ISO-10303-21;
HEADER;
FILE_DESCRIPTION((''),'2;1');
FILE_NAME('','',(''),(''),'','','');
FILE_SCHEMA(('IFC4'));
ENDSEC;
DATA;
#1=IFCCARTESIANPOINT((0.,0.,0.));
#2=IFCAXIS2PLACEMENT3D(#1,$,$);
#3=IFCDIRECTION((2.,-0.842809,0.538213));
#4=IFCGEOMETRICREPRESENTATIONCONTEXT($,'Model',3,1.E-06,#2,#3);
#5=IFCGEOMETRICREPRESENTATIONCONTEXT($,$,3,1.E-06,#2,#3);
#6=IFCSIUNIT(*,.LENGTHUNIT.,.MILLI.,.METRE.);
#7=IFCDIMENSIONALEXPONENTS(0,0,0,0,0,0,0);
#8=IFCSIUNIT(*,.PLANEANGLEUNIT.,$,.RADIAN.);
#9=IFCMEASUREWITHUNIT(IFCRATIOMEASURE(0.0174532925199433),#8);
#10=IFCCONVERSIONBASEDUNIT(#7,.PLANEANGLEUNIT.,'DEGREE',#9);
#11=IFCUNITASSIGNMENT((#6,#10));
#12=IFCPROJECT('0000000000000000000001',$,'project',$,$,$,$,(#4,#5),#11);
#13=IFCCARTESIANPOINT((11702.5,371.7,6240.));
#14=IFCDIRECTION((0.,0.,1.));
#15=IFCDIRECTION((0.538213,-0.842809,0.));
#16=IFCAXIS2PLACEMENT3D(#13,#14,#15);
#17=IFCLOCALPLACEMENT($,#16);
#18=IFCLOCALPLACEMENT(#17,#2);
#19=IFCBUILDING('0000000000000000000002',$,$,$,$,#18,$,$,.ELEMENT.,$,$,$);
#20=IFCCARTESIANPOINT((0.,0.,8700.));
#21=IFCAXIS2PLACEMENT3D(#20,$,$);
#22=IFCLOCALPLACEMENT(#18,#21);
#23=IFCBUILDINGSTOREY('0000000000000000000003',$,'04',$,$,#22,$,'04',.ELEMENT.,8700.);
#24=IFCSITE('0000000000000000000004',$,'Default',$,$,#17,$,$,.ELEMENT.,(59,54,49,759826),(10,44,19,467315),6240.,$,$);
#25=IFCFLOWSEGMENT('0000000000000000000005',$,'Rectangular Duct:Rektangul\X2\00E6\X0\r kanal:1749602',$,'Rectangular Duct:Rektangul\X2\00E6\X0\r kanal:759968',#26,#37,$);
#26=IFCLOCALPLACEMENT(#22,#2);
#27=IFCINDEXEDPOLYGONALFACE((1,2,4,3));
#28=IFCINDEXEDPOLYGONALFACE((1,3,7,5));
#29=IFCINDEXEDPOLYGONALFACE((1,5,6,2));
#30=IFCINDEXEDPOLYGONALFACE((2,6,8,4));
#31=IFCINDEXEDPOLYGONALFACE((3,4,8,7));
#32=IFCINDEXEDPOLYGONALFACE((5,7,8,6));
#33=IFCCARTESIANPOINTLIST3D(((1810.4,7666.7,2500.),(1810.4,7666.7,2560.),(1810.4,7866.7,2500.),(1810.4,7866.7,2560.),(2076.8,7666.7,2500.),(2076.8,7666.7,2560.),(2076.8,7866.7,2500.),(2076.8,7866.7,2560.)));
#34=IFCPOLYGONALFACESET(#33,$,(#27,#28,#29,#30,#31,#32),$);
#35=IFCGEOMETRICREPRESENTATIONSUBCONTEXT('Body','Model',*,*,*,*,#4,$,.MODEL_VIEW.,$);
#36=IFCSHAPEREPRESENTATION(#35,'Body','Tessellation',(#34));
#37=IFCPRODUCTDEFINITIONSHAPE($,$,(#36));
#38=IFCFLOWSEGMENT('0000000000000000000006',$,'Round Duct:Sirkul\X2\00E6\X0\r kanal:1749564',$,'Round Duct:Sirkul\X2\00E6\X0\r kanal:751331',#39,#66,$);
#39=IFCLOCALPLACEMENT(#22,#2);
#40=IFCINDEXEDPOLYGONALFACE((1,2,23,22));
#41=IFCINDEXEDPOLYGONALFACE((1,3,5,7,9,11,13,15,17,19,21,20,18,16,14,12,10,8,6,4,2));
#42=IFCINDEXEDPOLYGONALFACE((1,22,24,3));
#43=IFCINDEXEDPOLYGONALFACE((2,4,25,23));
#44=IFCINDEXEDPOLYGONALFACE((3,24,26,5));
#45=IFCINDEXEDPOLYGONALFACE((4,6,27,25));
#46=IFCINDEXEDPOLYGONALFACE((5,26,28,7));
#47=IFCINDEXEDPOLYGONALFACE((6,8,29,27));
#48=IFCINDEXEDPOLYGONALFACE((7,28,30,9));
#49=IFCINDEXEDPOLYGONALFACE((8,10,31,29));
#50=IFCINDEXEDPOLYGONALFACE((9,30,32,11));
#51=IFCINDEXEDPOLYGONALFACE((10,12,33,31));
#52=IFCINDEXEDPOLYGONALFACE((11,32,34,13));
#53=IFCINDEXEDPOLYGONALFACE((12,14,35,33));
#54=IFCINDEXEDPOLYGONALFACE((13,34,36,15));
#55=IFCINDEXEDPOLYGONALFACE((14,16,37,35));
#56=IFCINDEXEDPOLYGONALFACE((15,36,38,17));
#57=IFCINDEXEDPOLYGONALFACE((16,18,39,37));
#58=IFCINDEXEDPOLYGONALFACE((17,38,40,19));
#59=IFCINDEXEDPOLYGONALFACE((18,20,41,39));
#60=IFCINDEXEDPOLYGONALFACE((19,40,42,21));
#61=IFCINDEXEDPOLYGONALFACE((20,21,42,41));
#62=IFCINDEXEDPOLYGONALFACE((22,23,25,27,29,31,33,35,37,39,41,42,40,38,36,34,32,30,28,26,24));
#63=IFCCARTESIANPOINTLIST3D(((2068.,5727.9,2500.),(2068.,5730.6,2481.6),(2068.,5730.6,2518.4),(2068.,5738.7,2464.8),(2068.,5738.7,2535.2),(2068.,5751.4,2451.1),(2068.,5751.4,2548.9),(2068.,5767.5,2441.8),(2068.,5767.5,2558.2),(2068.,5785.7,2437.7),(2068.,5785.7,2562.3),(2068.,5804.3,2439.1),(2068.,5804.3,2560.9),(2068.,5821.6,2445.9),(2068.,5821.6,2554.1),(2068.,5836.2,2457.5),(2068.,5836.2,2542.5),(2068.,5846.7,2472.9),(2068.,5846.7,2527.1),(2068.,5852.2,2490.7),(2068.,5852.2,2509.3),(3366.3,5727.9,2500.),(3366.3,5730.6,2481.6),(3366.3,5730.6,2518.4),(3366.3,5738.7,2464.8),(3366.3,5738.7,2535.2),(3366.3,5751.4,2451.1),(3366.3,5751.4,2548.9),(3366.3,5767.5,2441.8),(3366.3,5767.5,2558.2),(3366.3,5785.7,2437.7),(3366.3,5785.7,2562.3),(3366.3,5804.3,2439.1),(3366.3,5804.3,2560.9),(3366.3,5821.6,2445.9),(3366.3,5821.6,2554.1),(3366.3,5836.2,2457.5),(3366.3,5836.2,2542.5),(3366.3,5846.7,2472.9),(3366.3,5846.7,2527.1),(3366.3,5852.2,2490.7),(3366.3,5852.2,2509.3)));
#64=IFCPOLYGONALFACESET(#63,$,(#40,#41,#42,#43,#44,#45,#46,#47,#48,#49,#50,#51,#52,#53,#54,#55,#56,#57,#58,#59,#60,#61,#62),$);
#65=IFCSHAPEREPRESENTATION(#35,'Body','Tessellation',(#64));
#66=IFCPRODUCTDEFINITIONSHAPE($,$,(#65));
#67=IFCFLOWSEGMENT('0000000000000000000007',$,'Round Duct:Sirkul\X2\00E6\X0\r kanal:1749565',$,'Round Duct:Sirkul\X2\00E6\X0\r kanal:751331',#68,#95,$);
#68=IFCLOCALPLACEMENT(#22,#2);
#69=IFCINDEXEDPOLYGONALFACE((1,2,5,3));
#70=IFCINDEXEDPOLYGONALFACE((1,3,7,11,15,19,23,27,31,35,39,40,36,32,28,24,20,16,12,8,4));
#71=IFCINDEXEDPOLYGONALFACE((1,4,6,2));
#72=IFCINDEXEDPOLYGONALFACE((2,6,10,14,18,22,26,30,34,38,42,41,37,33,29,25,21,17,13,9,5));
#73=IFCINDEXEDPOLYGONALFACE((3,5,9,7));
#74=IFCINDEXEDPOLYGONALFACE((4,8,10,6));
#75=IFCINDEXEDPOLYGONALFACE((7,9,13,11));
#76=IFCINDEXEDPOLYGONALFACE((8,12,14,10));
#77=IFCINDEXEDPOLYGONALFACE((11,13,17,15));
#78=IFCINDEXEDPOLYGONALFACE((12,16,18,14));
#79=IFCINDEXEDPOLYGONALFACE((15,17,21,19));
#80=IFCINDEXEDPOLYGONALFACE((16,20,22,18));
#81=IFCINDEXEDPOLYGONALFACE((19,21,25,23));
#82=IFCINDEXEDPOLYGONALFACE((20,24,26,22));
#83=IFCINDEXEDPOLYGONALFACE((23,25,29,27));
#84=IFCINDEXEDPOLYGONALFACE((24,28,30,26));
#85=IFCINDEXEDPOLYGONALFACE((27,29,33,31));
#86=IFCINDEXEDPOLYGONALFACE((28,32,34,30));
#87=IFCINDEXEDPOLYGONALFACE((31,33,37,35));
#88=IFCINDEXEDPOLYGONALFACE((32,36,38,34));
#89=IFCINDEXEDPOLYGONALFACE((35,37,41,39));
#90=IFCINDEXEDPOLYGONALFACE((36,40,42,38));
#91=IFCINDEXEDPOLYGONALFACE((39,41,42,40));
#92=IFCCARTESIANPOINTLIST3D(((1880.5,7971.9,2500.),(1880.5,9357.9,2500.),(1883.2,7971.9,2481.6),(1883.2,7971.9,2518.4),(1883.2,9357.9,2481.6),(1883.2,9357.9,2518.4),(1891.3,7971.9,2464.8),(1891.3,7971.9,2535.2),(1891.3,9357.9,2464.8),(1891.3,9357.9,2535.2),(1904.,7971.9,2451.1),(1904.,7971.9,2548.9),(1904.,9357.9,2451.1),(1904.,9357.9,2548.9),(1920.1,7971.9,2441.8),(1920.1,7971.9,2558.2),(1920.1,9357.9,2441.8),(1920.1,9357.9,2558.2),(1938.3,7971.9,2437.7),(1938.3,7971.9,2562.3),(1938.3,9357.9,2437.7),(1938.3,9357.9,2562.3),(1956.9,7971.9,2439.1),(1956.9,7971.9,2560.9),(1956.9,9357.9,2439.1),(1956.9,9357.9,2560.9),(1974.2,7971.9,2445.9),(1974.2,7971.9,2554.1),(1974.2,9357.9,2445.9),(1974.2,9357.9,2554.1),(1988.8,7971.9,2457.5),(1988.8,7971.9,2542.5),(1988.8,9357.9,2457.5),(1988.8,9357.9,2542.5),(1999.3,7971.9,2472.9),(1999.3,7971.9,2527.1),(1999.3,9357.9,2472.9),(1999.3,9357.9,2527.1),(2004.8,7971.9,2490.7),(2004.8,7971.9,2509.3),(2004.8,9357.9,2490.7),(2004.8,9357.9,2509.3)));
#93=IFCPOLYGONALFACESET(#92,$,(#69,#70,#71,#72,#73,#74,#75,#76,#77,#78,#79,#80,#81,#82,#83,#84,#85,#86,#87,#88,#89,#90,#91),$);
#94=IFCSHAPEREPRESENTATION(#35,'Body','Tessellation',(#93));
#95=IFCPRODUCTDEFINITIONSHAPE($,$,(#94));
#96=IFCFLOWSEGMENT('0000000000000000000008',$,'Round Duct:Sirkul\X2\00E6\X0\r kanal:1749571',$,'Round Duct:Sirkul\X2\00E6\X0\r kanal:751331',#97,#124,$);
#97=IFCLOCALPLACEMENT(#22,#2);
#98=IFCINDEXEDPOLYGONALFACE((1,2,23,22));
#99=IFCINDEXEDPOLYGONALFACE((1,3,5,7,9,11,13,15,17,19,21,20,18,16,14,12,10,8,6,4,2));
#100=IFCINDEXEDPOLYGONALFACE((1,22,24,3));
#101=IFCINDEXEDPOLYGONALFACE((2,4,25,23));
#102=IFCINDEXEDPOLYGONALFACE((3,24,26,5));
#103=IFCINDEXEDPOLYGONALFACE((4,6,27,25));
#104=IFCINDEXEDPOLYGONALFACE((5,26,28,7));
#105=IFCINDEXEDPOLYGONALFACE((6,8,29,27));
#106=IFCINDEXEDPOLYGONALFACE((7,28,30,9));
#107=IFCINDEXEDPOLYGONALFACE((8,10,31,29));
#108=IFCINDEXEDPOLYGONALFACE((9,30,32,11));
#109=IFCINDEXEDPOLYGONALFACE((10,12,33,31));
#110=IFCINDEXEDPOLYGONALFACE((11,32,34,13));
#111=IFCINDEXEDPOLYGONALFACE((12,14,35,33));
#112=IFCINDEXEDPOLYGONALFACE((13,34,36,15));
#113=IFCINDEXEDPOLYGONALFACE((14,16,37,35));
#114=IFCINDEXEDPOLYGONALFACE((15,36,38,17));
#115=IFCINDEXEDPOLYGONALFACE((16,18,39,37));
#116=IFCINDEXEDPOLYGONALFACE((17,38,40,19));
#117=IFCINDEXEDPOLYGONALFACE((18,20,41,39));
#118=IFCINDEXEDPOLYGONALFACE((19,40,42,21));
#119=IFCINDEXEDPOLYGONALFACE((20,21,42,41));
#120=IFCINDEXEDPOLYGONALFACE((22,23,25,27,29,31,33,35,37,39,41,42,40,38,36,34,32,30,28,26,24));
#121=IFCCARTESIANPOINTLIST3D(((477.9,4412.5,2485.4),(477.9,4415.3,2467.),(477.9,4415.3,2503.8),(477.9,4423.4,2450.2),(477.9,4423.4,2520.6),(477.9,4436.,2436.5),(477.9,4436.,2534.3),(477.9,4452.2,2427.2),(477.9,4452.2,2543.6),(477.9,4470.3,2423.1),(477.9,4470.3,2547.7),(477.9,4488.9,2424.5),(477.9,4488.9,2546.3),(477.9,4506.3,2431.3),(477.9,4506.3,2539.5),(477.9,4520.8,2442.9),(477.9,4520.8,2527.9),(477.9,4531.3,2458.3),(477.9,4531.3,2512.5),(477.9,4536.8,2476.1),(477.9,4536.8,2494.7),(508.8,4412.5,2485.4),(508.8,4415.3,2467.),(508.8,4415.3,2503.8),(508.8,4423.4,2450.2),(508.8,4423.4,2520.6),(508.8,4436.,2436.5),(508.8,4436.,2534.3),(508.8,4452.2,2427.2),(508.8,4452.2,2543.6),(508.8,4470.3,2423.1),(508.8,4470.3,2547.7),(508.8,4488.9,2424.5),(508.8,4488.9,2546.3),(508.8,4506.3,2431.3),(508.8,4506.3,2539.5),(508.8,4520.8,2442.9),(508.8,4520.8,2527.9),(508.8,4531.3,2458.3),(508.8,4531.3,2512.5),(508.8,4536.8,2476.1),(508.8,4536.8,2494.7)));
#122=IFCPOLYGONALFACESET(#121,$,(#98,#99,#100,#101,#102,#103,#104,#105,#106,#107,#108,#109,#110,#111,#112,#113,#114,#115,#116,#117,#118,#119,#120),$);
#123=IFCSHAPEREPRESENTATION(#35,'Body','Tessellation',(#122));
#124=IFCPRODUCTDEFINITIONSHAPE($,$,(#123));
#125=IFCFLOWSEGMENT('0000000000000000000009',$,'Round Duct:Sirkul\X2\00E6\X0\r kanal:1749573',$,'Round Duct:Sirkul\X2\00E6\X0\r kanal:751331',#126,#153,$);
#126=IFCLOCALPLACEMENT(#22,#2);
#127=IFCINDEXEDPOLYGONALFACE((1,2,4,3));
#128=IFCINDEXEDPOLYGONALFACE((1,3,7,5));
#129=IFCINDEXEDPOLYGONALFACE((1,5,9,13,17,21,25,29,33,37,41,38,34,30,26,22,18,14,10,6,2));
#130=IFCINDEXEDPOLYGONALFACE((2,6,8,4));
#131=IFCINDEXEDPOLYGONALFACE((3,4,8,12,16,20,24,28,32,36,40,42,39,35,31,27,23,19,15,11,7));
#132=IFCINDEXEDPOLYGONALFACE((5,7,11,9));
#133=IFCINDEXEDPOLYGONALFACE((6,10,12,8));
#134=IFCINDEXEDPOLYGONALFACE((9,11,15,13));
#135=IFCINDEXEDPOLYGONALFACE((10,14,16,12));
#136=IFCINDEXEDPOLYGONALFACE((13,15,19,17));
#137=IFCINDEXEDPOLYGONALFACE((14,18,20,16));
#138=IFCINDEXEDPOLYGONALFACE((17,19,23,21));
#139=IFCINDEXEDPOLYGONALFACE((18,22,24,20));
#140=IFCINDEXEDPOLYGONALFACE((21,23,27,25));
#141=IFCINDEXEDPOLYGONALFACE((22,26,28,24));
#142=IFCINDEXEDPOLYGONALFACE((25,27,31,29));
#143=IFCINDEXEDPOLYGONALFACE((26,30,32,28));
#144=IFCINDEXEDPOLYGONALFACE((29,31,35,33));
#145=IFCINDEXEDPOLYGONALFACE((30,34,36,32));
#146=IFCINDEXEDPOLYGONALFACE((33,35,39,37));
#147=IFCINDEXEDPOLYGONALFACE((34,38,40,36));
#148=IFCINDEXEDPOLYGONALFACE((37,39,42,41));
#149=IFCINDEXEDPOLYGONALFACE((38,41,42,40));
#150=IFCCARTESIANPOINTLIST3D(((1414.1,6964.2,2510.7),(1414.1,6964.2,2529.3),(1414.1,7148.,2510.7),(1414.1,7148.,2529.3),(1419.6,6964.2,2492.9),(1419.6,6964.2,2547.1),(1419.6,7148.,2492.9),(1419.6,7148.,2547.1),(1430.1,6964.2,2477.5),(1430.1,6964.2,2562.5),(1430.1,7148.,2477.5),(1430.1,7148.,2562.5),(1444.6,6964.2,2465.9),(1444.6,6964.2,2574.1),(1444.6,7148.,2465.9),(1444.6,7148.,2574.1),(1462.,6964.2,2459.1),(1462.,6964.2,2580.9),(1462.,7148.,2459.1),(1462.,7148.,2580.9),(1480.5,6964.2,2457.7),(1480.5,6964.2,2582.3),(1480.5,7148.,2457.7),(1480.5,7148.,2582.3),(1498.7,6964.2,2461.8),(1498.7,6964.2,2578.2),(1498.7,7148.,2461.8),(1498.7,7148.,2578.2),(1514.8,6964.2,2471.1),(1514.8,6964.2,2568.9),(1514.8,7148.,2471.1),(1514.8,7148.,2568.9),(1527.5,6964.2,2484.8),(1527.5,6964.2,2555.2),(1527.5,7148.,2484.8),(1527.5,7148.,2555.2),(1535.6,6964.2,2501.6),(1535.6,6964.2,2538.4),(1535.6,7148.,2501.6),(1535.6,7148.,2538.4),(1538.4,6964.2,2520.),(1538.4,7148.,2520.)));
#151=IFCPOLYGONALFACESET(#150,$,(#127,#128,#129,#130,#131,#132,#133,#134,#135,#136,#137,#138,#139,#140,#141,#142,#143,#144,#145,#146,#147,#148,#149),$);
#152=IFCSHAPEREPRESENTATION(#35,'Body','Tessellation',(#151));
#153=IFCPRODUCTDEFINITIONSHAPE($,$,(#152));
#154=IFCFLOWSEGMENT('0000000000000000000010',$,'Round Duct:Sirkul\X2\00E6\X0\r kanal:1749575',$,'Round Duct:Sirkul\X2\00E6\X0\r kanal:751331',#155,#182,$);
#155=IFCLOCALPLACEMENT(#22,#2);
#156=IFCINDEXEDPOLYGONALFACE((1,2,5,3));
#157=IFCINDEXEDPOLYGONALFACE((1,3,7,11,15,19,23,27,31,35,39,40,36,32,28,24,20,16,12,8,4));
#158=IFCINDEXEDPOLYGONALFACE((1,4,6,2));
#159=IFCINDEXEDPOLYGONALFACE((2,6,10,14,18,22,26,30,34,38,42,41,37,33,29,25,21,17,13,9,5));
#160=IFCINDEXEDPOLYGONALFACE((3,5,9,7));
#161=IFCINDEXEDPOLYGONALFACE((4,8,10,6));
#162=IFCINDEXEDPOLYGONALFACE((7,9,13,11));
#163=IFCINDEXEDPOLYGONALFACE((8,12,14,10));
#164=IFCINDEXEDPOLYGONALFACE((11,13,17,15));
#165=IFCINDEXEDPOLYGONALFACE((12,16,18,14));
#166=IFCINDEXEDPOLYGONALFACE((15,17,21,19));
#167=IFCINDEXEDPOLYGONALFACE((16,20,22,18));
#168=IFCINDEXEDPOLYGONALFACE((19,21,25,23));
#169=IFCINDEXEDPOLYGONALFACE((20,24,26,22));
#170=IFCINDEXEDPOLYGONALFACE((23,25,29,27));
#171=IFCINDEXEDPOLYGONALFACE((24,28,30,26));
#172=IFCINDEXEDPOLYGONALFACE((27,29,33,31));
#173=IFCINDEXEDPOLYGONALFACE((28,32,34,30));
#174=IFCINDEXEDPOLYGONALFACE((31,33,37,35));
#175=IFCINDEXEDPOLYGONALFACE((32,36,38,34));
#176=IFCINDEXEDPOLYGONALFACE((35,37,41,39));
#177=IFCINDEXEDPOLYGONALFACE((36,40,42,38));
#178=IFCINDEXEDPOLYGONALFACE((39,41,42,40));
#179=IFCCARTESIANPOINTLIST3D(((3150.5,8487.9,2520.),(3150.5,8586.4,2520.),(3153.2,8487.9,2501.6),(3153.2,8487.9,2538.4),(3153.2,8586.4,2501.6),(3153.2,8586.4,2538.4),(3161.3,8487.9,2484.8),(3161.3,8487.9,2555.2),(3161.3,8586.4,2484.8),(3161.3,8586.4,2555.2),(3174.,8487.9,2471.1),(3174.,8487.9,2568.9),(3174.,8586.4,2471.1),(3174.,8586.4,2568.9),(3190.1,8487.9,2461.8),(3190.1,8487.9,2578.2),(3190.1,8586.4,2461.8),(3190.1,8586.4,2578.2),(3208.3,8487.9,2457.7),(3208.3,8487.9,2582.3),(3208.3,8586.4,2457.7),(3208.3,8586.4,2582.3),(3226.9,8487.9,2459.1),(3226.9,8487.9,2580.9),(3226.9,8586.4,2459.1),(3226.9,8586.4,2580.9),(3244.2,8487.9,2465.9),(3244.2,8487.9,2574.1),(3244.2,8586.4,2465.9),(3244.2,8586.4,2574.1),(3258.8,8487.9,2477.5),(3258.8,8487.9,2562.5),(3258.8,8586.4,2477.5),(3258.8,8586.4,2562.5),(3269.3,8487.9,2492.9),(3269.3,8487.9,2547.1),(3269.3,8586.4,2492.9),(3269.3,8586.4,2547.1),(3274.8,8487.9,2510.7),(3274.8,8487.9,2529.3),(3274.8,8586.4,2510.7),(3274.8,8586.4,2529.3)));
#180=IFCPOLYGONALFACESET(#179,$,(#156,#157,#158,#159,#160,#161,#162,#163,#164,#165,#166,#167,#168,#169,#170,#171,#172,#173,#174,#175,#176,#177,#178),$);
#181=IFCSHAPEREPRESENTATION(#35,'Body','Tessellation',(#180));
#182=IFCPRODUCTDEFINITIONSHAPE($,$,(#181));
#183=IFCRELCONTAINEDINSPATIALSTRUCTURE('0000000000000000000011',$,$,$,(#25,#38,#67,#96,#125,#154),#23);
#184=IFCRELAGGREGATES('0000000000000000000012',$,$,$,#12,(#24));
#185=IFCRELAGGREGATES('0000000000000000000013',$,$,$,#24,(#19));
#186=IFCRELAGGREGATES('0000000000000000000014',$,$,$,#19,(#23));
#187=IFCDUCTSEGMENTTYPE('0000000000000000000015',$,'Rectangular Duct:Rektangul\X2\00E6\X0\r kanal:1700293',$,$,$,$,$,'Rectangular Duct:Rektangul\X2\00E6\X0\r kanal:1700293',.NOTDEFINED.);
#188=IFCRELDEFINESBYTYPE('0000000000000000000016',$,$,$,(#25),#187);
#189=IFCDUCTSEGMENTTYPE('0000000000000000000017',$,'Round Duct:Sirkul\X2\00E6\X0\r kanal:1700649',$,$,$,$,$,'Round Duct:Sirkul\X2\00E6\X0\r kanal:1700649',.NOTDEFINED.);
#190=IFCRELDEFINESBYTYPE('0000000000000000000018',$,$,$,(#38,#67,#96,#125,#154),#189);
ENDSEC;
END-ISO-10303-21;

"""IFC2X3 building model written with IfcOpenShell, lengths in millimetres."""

from ifc_helpers import new_model, entity, si_unit, converted_unit, direction, frame, frame_2d, origin, origin_2d_with_axis, place, context, subcontext, project, spatial, rectangle, circle, extrude, type_object, element, save


model = new_model("IFC2X3")

# Units and contexts
model_context = context("Model", 3, precision=1e-06, world=origin(), true_north=direction((2.0, -0.842809, 0.538213)))
context_of_model = context(None, 3, precision=1e-06, world=origin(), true_north=direction((2.0, -0.842809, 0.538213)))
body_context = subcontext(model_context, "Body", "Model", "MODEL_VIEW")
ifc_project = project(units=[si_unit("LENGTHUNIT", "METRE", prefix="MILLI"), converted_unit("PLANEANGLEUNIT", "DEGREE", entity("IfcRatioMeasure", 0.0174532925199433), si_unit("PLANEANGLEUNIT", "RADIAN"), dimensions=[0, 0, 0, 0, 0, 0, 0])], contexts=[model_context, context_of_model])

# Site, building, storey
site_placement = place(None, frame((11702.5, 371.7, 6240.0), z_axis=(0.0, 0.0, 1.0), x_axis=(0.538213, -0.842809, 0.0)))
site = spatial("IfcSite", under=ifc_project, at=site_placement, Name="Default", CompositionType="ELEMENT", RefLatitude=(59, 54, 49, 759826), RefLongitude=(10, 44, 19, 467315), RefElevation=6240.0)
building_placement = place(site_placement, origin())
building = spatial("IfcBuilding", under=site, at=building_placement, CompositionType="ELEMENT")
storey_placement = place(building_placement, frame((0.0, 0.0, 8700.0)))
storey = spatial("IfcBuildingStorey", under=building, at=storey_placement, Name="04", LongName="04", CompositionType="ELEMENT", Elevation=8700.0)

# Flow segments
duct_segment_type_1 = type_object("IfcDuctSegmentType", Name="Rectangular Duct:Rektangulær kanal:1700293", ElementType="Rectangular Duct:Rektangulær kanal:1700293", PredefinedType="NOTDEFINED")
flow_segment_1_placement = place(storey_placement, origin())
element("IfcFlowSegment", 1, at=flow_segment_1_placement, inside=storey, type_object=duct_segment_type_1, Name="Rectangular Duct:Rektangulær kanal:1749602", ObjectType="Rectangular Duct:Rektangulær kanal:759968", context=body_context, shape_type="SweptSolid", body=[
    extrude(rectangle(XDim=266.4, YDim=200.0, at=origin_2d_with_axis()), frame((1943.6, 7766.7, 2500.0)), (0.0, 0.0, 1.0), 60.0),
])
duct_segment_type_2 = type_object("IfcDuctSegmentType", Name="Round Duct:Sirkulær kanal:1700649", ElementType="Round Duct:Sirkulær kanal:1700649", PredefinedType="NOTDEFINED")
flow_segment_2_placement = place(storey_placement, origin())
element("IfcFlowSegment", 2, at=flow_segment_2_placement, inside=storey, type_object=duct_segment_type_2, Name="Round Duct:Sirkulær kanal:1749564", ObjectType="Round Duct:Sirkulær kanal:751331", context=body_context, shape_type="SweptSolid", body=[
    extrude(circle(Radius=62.5, at=origin_2d_with_axis()), frame((2068.0, 5790.4, 2500.0), z_axis=(1.0, 0.0, 0.0), x_axis=(0.0, -1.0, 0.0)), (0.0, 0.0, 1.0), 1298.3),
])
flow_segment_3_placement = place(storey_placement, origin())
element("IfcFlowSegment", 3, at=flow_segment_3_placement, inside=storey, type_object=duct_segment_type_2, Name="Round Duct:Sirkulær kanal:1749565", ObjectType="Round Duct:Sirkulær kanal:751331", context=body_context, shape_type="SweptSolid", body=[
    extrude(circle(Radius=62.5, at=frame_2d((0.0, 0.0), x_axis=(1.0, 0.0))), frame((1943.0, 7971.9, 2500.0), z_axis=(0.0, 1.0, 0.0), x_axis=(-1.0, 0.0, 0.0)), (0.0, 0.0, 1.0), 1386.0),
])
flow_segment_4_placement = place(storey_placement, origin())
element("IfcFlowSegment", 4, at=flow_segment_4_placement, inside=storey, type_object=duct_segment_type_2, Name="Round Duct:Sirkulær kanal:1749571", ObjectType="Round Duct:Sirkulær kanal:751331", context=body_context, shape_type="SweptSolid", body=[
    extrude(circle(Radius=62.5, at=origin_2d_with_axis()), frame((477.9, 4475.0, 2485.4), z_axis=(1.0, 0.0, 0.0), x_axis=(0.0, -1.0, 0.0)), (0.0, 0.0, 1.0), 30.9),
])
flow_segment_5_placement = place(storey_placement, origin())
element("IfcFlowSegment", 5, at=flow_segment_5_placement, inside=storey, type_object=duct_segment_type_2, Name="Round Duct:Sirkulær kanal:1749573", ObjectType="Round Duct:Sirkulær kanal:751331", context=body_context, shape_type="SweptSolid", body=[
    extrude(circle(Radius=62.5, at=origin_2d_with_axis()), frame((1475.9, 6964.2, 2520.0), z_axis=(0.0, 1.0, 0.0), x_axis=(1.0, 0.0, 0.0)), (0.0, 0.0, 1.0), 183.7),
])
flow_segment_6_placement = place(storey_placement, origin())
element("IfcFlowSegment", 6, at=flow_segment_6_placement, inside=storey, type_object=duct_segment_type_2, Name="Round Duct:Sirkulær kanal:1749575", ObjectType="Round Duct:Sirkulær kanal:751331", context=body_context, shape_type="SweptSolid", body=[
    extrude(circle(Radius=62.5, at=origin_2d_with_axis()), frame((3213.0, 8487.9, 2520.0), z_axis=(0.0, 1.0, 0.0), x_axis=(-1.0, 0.0, 0.0)), (0.0, 0.0, 1.0), 98.4),
])

save(model, "model.ifc")
